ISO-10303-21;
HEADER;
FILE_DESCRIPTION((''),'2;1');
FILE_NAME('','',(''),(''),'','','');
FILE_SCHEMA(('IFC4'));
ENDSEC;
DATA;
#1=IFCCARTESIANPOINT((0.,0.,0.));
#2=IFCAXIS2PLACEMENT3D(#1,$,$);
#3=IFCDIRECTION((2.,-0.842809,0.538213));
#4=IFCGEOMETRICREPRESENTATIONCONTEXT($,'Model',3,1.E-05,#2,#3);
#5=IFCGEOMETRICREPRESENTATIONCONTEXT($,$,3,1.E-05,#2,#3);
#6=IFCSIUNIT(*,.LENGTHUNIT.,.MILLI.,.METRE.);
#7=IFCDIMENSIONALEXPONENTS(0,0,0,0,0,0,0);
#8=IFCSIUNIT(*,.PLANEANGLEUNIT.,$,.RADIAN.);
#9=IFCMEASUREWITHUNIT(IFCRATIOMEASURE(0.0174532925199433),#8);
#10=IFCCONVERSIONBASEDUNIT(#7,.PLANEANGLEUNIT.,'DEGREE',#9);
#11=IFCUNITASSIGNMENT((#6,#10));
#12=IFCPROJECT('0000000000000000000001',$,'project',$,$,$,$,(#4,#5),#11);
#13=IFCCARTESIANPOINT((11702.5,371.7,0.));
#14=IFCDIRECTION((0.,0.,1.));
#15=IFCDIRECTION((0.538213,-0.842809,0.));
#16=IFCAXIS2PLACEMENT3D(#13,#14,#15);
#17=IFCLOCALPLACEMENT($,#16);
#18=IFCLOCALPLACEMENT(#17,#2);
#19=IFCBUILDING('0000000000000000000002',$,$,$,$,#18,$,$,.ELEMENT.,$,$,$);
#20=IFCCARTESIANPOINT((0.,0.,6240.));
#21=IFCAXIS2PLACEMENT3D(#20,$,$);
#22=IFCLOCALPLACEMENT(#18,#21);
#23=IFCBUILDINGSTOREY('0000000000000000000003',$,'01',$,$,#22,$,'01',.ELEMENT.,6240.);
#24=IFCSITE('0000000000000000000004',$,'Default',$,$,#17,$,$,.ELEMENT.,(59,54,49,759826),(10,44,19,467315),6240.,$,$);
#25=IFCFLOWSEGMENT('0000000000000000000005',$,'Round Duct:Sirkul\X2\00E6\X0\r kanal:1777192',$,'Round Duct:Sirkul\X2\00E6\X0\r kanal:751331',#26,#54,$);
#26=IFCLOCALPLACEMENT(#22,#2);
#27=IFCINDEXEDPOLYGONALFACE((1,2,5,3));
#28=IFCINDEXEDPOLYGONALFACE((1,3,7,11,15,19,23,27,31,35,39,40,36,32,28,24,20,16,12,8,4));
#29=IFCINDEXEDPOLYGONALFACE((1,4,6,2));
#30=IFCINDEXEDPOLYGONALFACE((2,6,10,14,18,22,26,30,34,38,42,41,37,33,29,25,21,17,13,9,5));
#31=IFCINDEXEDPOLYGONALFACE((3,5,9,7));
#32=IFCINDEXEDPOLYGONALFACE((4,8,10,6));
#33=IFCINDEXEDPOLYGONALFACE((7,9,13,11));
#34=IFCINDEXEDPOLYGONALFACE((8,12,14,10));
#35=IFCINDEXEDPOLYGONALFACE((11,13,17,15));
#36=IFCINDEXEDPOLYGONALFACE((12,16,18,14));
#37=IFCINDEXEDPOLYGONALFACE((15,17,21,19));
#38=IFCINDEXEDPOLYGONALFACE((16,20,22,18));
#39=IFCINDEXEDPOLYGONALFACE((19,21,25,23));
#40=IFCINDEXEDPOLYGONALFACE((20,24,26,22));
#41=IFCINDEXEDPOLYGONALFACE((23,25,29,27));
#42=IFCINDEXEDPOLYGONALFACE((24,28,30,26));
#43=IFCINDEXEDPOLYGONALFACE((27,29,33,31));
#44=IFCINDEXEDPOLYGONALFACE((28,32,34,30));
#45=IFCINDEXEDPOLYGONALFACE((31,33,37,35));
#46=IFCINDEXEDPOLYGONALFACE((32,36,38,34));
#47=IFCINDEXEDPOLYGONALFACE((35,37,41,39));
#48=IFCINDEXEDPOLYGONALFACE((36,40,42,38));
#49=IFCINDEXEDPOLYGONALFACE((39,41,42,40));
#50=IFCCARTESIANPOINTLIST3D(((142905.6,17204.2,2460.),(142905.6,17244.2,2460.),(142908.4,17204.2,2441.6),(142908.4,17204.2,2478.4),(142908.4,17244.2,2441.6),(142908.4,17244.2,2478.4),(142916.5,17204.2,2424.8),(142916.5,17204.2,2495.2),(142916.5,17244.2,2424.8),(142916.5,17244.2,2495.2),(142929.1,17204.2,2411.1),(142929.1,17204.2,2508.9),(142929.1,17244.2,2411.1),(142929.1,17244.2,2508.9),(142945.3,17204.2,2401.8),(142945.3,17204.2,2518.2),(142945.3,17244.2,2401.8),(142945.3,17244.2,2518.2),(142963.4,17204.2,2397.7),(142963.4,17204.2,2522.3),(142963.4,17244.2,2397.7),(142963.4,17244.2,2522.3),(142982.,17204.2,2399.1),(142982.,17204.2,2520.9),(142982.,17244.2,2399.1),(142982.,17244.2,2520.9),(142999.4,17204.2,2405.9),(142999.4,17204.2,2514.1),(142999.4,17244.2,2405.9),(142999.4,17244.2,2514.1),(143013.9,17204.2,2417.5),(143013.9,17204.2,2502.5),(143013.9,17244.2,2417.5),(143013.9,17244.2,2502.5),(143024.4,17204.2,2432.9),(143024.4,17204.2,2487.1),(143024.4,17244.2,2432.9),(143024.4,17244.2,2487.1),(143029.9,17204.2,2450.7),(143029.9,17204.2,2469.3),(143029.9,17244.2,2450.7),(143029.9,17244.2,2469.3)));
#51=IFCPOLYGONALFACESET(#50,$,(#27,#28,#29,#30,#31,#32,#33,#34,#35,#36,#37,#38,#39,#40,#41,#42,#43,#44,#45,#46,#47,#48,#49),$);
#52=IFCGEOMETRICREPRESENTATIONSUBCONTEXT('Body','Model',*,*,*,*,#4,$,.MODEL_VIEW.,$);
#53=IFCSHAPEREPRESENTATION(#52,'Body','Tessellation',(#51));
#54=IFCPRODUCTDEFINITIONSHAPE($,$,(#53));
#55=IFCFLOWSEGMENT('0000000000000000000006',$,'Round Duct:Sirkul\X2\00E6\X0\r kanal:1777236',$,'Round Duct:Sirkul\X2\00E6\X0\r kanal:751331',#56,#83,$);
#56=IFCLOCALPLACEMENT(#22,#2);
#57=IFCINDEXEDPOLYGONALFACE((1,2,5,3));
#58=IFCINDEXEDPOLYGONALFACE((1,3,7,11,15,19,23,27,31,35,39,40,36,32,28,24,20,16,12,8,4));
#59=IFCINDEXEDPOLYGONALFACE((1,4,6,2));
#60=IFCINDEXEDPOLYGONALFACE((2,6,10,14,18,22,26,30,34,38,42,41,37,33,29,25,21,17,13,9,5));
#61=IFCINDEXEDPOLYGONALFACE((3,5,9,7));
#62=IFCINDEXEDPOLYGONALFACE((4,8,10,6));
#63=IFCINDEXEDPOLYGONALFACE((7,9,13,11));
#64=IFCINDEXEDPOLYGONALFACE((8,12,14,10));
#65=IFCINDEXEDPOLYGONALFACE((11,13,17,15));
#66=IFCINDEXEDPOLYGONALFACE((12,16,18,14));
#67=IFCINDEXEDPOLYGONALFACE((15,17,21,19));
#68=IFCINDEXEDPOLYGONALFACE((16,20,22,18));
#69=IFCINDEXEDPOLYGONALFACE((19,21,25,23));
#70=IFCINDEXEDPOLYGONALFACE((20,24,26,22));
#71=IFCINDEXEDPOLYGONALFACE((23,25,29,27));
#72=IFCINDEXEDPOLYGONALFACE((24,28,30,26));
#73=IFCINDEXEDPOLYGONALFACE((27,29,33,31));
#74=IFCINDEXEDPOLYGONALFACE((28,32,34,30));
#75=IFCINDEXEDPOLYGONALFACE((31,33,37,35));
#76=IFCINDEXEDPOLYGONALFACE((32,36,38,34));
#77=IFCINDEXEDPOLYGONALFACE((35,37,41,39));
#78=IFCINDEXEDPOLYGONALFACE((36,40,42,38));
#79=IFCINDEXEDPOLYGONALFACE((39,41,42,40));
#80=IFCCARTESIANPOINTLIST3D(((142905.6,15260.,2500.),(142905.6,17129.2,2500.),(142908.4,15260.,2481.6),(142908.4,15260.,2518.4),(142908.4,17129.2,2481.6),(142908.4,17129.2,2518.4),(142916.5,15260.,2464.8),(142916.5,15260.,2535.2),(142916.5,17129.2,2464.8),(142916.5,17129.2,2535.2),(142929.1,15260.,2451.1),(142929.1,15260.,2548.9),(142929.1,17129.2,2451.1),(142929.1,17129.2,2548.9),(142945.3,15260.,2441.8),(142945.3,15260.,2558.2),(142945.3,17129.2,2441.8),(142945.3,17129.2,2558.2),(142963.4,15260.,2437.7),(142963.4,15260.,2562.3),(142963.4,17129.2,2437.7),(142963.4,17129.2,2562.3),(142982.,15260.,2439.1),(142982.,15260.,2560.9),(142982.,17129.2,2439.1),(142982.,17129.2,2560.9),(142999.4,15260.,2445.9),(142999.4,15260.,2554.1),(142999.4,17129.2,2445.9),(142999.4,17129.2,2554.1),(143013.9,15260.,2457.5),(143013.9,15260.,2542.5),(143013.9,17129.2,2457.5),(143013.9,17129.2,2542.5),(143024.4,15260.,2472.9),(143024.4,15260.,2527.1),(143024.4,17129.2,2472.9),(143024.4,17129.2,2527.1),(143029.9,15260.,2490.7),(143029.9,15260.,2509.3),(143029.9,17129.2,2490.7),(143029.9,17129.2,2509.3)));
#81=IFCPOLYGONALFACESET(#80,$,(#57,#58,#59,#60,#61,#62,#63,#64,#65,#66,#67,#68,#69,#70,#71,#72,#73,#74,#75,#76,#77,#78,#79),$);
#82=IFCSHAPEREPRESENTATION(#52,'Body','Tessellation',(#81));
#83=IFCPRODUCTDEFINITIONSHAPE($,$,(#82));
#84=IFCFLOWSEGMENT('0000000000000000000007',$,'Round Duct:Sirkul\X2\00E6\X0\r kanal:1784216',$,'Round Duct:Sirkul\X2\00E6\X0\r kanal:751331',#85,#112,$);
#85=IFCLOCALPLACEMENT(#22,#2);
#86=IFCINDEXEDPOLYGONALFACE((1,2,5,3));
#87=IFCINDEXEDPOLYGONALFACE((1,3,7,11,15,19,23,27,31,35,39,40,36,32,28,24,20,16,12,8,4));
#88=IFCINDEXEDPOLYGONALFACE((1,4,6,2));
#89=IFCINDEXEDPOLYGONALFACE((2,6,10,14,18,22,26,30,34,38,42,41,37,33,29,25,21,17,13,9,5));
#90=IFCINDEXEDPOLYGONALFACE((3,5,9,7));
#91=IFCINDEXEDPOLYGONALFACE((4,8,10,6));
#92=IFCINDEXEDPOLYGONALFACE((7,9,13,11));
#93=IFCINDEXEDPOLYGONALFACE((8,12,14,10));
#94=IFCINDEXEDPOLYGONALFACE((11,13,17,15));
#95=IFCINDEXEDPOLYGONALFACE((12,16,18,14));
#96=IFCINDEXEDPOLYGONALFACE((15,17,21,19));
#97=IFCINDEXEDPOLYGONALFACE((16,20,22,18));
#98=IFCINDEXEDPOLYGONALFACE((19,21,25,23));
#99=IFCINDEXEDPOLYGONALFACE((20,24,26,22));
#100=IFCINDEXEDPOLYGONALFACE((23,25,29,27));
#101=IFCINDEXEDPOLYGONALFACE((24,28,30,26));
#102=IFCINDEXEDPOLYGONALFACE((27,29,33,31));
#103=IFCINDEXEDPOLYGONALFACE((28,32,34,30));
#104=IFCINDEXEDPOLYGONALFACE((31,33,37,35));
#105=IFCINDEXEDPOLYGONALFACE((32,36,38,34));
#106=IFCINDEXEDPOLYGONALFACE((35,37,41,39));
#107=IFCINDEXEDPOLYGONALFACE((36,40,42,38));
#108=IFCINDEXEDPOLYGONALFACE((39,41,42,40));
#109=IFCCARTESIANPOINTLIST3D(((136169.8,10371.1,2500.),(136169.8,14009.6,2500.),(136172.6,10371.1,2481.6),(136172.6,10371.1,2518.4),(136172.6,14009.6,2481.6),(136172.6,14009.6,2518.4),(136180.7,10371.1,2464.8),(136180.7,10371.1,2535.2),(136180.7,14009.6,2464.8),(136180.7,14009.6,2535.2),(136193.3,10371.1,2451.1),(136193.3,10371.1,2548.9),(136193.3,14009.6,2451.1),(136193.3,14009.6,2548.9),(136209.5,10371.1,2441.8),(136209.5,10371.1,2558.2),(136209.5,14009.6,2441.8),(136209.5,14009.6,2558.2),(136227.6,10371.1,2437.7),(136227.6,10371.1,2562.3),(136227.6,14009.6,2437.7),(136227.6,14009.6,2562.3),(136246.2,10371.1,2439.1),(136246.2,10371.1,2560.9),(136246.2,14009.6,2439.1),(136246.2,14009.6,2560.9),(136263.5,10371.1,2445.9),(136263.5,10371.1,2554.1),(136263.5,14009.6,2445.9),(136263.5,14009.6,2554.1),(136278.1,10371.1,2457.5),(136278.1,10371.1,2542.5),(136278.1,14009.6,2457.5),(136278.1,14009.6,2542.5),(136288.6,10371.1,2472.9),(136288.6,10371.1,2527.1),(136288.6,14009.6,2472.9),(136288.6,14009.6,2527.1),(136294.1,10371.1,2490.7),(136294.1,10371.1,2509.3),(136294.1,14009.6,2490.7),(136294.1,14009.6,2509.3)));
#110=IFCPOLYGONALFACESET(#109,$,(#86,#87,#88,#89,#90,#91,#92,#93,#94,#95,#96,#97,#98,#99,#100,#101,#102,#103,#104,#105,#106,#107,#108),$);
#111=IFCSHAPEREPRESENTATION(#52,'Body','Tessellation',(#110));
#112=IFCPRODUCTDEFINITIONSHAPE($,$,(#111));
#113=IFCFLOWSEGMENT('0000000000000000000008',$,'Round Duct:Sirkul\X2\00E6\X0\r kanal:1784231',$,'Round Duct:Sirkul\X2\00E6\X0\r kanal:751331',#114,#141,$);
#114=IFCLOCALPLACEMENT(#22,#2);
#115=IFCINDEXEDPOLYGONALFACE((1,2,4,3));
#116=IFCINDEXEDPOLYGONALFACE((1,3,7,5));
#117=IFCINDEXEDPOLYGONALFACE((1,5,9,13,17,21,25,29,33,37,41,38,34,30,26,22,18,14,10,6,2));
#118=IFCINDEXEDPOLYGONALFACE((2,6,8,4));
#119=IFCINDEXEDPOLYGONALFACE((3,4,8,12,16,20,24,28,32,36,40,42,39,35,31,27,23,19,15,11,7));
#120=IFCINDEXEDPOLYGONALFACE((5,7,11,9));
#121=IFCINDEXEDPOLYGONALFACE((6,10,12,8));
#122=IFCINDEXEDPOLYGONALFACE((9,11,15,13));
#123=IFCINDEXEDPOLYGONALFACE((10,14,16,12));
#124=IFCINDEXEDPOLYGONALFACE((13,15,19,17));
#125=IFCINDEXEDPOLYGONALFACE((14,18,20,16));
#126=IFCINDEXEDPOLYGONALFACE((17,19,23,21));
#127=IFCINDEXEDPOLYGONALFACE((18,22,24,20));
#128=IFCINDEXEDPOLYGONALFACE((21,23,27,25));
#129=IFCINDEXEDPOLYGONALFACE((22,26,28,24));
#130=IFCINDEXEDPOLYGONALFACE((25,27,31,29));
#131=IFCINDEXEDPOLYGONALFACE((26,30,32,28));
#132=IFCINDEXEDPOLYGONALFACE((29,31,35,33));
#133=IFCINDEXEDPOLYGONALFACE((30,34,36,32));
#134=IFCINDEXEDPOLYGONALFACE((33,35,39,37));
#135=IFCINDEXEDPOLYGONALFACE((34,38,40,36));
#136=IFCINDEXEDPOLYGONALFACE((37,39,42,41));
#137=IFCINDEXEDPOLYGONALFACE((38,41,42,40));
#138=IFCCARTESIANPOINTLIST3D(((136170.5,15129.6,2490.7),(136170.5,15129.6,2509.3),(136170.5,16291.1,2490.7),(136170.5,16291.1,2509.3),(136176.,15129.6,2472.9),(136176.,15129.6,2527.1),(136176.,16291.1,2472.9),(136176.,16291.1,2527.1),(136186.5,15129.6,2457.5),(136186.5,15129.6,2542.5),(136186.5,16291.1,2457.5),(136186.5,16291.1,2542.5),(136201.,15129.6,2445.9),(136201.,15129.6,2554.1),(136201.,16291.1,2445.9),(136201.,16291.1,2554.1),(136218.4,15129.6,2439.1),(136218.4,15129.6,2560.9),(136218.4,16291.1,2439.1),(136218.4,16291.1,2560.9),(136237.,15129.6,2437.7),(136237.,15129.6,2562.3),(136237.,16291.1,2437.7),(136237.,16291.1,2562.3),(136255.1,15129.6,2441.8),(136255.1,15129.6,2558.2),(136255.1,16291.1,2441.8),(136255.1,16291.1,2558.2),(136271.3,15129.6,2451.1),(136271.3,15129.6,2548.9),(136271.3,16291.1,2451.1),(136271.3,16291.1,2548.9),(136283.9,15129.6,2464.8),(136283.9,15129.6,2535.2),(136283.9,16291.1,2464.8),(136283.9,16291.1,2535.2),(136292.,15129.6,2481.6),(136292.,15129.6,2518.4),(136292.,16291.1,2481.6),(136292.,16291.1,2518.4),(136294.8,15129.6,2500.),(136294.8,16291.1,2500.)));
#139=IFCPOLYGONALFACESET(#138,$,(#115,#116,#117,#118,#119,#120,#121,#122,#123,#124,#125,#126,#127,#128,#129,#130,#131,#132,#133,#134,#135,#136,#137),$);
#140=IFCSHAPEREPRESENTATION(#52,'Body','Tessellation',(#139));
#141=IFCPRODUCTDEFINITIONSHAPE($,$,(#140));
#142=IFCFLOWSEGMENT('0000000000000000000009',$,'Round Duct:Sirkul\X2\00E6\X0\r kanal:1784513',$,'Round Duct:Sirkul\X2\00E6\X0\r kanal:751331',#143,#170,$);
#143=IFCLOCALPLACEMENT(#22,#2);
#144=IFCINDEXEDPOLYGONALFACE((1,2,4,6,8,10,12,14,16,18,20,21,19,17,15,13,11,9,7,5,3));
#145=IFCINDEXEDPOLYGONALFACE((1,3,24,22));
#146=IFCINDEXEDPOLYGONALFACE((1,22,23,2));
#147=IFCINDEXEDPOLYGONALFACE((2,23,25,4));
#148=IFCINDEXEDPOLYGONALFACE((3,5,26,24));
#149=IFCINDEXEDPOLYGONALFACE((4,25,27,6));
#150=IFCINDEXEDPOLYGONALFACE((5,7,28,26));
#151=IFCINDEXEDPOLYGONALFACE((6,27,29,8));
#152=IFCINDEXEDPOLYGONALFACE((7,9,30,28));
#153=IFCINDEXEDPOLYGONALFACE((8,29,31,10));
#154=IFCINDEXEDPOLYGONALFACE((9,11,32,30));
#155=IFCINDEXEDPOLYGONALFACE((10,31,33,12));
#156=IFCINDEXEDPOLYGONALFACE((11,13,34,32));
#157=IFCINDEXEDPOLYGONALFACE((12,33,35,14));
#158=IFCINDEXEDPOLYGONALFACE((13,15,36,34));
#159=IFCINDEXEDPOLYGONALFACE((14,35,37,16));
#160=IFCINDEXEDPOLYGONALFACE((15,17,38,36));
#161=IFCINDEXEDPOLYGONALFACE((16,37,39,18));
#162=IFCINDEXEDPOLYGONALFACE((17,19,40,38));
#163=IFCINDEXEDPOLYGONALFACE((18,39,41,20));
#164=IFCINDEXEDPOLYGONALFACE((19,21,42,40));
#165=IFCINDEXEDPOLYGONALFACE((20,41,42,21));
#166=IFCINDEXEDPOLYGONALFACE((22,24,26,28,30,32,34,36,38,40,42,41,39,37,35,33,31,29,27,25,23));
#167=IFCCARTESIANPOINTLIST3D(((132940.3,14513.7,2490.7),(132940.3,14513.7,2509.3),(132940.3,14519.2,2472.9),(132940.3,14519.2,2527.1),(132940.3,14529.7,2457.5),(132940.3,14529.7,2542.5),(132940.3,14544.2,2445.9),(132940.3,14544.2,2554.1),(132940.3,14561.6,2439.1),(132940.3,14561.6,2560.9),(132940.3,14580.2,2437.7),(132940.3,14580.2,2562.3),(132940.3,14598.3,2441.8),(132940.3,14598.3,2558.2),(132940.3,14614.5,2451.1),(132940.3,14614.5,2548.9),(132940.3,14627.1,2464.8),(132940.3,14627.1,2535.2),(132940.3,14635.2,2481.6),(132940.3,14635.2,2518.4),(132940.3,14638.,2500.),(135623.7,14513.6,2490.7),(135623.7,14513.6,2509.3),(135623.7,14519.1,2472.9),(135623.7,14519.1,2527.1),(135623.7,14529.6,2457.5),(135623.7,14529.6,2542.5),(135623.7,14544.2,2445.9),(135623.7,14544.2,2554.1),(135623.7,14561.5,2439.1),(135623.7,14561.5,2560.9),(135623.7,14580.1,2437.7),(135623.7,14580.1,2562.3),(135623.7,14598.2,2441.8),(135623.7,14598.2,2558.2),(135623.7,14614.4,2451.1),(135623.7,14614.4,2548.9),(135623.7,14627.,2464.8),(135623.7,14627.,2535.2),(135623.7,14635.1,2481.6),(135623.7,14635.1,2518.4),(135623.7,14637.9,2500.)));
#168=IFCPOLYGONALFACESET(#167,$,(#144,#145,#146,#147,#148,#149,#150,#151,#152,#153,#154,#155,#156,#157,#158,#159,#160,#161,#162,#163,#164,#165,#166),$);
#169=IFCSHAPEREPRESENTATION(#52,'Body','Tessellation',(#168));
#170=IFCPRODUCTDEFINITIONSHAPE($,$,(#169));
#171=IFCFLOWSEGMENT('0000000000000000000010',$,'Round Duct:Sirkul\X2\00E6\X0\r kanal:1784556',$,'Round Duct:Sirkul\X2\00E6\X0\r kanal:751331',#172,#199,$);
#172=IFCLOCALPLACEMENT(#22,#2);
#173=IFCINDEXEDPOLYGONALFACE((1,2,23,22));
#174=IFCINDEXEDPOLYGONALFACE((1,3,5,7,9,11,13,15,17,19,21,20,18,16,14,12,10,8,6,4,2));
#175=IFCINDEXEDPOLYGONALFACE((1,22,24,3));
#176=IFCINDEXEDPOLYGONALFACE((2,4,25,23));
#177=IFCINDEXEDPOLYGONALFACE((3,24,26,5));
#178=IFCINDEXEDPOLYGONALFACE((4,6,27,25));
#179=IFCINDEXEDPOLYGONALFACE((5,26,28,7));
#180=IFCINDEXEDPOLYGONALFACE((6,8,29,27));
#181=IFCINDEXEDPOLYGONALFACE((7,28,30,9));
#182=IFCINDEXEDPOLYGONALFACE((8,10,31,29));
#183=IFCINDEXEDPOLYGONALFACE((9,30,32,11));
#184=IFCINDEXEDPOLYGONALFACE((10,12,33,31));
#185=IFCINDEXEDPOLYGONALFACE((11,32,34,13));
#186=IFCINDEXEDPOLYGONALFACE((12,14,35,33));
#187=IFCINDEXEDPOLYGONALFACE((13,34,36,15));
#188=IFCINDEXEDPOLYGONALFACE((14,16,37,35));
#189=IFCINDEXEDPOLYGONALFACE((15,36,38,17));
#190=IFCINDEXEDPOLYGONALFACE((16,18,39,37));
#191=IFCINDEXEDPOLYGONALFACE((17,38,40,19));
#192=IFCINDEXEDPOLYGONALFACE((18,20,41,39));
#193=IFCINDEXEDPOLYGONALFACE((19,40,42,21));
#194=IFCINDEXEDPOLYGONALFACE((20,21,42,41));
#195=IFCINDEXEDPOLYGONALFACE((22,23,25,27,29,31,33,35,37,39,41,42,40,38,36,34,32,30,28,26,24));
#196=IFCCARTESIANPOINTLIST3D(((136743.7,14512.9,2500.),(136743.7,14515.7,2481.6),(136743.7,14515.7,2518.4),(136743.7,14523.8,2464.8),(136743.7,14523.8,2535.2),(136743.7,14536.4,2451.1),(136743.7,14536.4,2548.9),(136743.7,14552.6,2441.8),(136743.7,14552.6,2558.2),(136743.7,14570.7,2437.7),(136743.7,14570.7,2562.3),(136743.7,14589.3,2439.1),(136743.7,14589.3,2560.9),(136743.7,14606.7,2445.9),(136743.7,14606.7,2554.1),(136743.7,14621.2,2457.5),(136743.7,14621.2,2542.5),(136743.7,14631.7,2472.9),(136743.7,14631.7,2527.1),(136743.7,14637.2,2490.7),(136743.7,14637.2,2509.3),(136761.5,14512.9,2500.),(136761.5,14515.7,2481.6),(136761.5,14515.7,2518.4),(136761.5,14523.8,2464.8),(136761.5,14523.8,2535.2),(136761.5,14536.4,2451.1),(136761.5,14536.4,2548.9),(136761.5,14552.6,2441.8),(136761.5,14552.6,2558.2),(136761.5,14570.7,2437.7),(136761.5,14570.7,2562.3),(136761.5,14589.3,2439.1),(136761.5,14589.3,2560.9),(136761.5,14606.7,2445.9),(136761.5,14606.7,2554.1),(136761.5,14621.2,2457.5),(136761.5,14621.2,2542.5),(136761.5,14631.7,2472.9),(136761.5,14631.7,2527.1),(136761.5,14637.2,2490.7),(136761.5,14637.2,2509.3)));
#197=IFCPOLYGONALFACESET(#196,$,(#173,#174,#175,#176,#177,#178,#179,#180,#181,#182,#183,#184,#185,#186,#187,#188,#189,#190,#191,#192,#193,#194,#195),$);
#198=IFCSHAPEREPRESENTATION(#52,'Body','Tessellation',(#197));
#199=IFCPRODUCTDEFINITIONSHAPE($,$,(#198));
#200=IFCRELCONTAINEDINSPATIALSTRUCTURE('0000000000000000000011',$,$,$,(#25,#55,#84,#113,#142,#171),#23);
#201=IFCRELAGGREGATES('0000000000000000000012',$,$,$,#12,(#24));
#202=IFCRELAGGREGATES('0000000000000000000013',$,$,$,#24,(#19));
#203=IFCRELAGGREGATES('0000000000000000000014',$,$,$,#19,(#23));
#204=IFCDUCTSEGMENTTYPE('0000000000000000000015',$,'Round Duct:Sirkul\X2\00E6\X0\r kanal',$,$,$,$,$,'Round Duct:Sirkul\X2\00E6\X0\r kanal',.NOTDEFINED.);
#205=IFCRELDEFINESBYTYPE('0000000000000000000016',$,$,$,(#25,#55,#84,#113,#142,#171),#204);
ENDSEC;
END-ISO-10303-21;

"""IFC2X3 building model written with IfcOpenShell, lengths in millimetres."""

from ifc_helpers import new_model, entity, si_unit, converted_unit, direction, frame, frame_2d, origin, origin_2d_with_axis, place, context, subcontext, project, spatial, circle, extrude, type_object, element, save


model = new_model("IFC2X3")

# Units and contexts
model_context = context("Model", 3, precision=1e-05, world=origin(), true_north=direction((2.0, -0.842809, 0.538213)))
context_of_model = context(None, 3, precision=1e-05, world=origin(), true_north=direction((2.0, -0.842809, 0.538213)))
body_context = subcontext(model_context, "Body", "Model", "MODEL_VIEW")
ifc_project = project(units=[si_unit("LENGTHUNIT", "METRE", prefix="MILLI"), converted_unit("PLANEANGLEUNIT", "DEGREE", entity("IfcRatioMeasure", 0.0174532925199433), si_unit("PLANEANGLEUNIT", "RADIAN"), dimensions=[0, 0, 0, 0, 0, 0, 0])], contexts=[model_context, context_of_model])

# Site, building, storey
site_placement = place(None, frame((11702.5, 371.7, 0.0), z_axis=(0.0, 0.0, 1.0), x_axis=(0.538213, -0.842809, 0.0)))
site = spatial("IfcSite", under=ifc_project, at=site_placement, Name="Default", CompositionType="ELEMENT", RefLatitude=(59, 54, 49, 759826), RefLongitude=(10, 44, 19, 467315), RefElevation=6240.0)
building_placement = place(site_placement, origin())
building = spatial("IfcBuilding", under=site, at=building_placement, CompositionType="ELEMENT")
storey_placement = place(building_placement, frame((0.0, 0.0, 6240.0)))
storey = spatial("IfcBuildingStorey", under=building, at=storey_placement, Name="01", LongName="01", CompositionType="ELEMENT", Elevation=6240.0)

# Flow segments
duct_segment_type_1 = type_object("IfcDuctSegmentType", Name="Round Duct:Sirkulær kanal", ElementType="Round Duct:Sirkulær kanal", PredefinedType="NOTDEFINED")
flow_segment_1_placement = place(storey_placement, origin())
element("IfcFlowSegment", 1, at=flow_segment_1_placement, inside=storey, type_object=duct_segment_type_1, Name="Round Duct:Sirkulær kanal:1777192", ObjectType="Round Duct:Sirkulær kanal:751331", context=body_context, shape_type="SweptSolid", body=[
    extrude(circle(Radius=62.5, at=frame_2d((0.0, 0.0), x_axis=(1.0, 0.0))), frame((142968.1, 17204.2, 2460.0), z_axis=(0.0, 1.0, 0.0), x_axis=(-1.0, 0.0, 0.0)), (0.0, 0.0, 1.0), 40.0),
])
flow_segment_2_placement = place(storey_placement, origin())
element("IfcFlowSegment", 2, at=flow_segment_2_placement, inside=storey, type_object=duct_segment_type_1, Name="Round Duct:Sirkulær kanal:1777236", ObjectType="Round Duct:Sirkulær kanal:751331", context=body_context, shape_type="SweptSolid", body=[
    extrude(circle(Radius=62.5, at=frame_2d((0.0, 0.0), x_axis=(1.0, 0.0))), frame((142968.1, 15260.0, 2500.0), z_axis=(0.0, 1.0, 0.0), x_axis=(-1.0, 0.0, 0.0)), (0.0, 0.0, 1.0), 1869.1),
])
flow_segment_3_placement = place(storey_placement, origin())
element("IfcFlowSegment", 3, at=flow_segment_3_placement, inside=storey, type_object=duct_segment_type_1, Name="Round Duct:Sirkulær kanal:1784216", ObjectType="Round Duct:Sirkulær kanal:751331", context=body_context, shape_type="SweptSolid", body=[
    extrude(circle(Radius=62.5, at=frame_2d((0.0, 0.0), x_axis=(1.0, 0.0))), frame((136232.3, 10371.1, 2500.0), z_axis=(0.0, 1.0, 0.0), x_axis=(-1.0, 0.0, 0.0)), (0.0, 0.0, 1.0), 3638.5),
])
flow_segment_4_placement = place(storey_placement, origin())
element("IfcFlowSegment", 4, at=flow_segment_4_placement, inside=storey, type_object=duct_segment_type_1, Name="Round Duct:Sirkulær kanal:1784231", ObjectType="Round Duct:Sirkulær kanal:751331", context=body_context, shape_type="SweptSolid", body=[
    extrude(circle(Radius=62.5, at=origin_2d_with_axis()), frame((136232.3, 15129.6, 2500.0), z_axis=(0.0, 1.0, 0.0), x_axis=(1.0, 0.0, 0.0)), (0.0, 0.0, 1.0), 1161.5),
])
flow_segment_5_placement = place(storey_placement, origin())
element("IfcFlowSegment", 5, at=flow_segment_5_placement, inside=storey, type_object=duct_segment_type_1, Name="Round Duct:Sirkulær kanal:1784513", ObjectType="Round Duct:Sirkulær kanal:751331", context=body_context, shape_type="SweptSolid", body=[
    extrude(circle(Radius=62.5, at=origin_2d_with_axis()), frame((132940.3, 14575.5, 2500.0), z_axis=(1.0, -0.000029, 0.0), x_axis=(0.000029, 1.0, 0.0)), (0.0, 0.0, 1.0), 2683.5),
])
flow_segment_6_placement = place(storey_placement, origin())
element("IfcFlowSegment", 6, at=flow_segment_6_placement, inside=storey, type_object=duct_segment_type_1, Name="Round Duct:Sirkulær kanal:1784556", ObjectType="Round Duct:Sirkulær kanal:751331", context=body_context, shape_type="SweptSolid", body=[
    extrude(circle(Radius=62.5, at=frame_2d((0.0, 0.0), x_axis=(1.0, 0.0))), frame((136743.7, 14575.4, 2500.0), z_axis=(1.0, 0.0, 0.0), x_axis=(0.0, -1.0, 0.0)), (0.0, 0.0, 1.0), 17.8),
])

save(model, "model.ifc")
